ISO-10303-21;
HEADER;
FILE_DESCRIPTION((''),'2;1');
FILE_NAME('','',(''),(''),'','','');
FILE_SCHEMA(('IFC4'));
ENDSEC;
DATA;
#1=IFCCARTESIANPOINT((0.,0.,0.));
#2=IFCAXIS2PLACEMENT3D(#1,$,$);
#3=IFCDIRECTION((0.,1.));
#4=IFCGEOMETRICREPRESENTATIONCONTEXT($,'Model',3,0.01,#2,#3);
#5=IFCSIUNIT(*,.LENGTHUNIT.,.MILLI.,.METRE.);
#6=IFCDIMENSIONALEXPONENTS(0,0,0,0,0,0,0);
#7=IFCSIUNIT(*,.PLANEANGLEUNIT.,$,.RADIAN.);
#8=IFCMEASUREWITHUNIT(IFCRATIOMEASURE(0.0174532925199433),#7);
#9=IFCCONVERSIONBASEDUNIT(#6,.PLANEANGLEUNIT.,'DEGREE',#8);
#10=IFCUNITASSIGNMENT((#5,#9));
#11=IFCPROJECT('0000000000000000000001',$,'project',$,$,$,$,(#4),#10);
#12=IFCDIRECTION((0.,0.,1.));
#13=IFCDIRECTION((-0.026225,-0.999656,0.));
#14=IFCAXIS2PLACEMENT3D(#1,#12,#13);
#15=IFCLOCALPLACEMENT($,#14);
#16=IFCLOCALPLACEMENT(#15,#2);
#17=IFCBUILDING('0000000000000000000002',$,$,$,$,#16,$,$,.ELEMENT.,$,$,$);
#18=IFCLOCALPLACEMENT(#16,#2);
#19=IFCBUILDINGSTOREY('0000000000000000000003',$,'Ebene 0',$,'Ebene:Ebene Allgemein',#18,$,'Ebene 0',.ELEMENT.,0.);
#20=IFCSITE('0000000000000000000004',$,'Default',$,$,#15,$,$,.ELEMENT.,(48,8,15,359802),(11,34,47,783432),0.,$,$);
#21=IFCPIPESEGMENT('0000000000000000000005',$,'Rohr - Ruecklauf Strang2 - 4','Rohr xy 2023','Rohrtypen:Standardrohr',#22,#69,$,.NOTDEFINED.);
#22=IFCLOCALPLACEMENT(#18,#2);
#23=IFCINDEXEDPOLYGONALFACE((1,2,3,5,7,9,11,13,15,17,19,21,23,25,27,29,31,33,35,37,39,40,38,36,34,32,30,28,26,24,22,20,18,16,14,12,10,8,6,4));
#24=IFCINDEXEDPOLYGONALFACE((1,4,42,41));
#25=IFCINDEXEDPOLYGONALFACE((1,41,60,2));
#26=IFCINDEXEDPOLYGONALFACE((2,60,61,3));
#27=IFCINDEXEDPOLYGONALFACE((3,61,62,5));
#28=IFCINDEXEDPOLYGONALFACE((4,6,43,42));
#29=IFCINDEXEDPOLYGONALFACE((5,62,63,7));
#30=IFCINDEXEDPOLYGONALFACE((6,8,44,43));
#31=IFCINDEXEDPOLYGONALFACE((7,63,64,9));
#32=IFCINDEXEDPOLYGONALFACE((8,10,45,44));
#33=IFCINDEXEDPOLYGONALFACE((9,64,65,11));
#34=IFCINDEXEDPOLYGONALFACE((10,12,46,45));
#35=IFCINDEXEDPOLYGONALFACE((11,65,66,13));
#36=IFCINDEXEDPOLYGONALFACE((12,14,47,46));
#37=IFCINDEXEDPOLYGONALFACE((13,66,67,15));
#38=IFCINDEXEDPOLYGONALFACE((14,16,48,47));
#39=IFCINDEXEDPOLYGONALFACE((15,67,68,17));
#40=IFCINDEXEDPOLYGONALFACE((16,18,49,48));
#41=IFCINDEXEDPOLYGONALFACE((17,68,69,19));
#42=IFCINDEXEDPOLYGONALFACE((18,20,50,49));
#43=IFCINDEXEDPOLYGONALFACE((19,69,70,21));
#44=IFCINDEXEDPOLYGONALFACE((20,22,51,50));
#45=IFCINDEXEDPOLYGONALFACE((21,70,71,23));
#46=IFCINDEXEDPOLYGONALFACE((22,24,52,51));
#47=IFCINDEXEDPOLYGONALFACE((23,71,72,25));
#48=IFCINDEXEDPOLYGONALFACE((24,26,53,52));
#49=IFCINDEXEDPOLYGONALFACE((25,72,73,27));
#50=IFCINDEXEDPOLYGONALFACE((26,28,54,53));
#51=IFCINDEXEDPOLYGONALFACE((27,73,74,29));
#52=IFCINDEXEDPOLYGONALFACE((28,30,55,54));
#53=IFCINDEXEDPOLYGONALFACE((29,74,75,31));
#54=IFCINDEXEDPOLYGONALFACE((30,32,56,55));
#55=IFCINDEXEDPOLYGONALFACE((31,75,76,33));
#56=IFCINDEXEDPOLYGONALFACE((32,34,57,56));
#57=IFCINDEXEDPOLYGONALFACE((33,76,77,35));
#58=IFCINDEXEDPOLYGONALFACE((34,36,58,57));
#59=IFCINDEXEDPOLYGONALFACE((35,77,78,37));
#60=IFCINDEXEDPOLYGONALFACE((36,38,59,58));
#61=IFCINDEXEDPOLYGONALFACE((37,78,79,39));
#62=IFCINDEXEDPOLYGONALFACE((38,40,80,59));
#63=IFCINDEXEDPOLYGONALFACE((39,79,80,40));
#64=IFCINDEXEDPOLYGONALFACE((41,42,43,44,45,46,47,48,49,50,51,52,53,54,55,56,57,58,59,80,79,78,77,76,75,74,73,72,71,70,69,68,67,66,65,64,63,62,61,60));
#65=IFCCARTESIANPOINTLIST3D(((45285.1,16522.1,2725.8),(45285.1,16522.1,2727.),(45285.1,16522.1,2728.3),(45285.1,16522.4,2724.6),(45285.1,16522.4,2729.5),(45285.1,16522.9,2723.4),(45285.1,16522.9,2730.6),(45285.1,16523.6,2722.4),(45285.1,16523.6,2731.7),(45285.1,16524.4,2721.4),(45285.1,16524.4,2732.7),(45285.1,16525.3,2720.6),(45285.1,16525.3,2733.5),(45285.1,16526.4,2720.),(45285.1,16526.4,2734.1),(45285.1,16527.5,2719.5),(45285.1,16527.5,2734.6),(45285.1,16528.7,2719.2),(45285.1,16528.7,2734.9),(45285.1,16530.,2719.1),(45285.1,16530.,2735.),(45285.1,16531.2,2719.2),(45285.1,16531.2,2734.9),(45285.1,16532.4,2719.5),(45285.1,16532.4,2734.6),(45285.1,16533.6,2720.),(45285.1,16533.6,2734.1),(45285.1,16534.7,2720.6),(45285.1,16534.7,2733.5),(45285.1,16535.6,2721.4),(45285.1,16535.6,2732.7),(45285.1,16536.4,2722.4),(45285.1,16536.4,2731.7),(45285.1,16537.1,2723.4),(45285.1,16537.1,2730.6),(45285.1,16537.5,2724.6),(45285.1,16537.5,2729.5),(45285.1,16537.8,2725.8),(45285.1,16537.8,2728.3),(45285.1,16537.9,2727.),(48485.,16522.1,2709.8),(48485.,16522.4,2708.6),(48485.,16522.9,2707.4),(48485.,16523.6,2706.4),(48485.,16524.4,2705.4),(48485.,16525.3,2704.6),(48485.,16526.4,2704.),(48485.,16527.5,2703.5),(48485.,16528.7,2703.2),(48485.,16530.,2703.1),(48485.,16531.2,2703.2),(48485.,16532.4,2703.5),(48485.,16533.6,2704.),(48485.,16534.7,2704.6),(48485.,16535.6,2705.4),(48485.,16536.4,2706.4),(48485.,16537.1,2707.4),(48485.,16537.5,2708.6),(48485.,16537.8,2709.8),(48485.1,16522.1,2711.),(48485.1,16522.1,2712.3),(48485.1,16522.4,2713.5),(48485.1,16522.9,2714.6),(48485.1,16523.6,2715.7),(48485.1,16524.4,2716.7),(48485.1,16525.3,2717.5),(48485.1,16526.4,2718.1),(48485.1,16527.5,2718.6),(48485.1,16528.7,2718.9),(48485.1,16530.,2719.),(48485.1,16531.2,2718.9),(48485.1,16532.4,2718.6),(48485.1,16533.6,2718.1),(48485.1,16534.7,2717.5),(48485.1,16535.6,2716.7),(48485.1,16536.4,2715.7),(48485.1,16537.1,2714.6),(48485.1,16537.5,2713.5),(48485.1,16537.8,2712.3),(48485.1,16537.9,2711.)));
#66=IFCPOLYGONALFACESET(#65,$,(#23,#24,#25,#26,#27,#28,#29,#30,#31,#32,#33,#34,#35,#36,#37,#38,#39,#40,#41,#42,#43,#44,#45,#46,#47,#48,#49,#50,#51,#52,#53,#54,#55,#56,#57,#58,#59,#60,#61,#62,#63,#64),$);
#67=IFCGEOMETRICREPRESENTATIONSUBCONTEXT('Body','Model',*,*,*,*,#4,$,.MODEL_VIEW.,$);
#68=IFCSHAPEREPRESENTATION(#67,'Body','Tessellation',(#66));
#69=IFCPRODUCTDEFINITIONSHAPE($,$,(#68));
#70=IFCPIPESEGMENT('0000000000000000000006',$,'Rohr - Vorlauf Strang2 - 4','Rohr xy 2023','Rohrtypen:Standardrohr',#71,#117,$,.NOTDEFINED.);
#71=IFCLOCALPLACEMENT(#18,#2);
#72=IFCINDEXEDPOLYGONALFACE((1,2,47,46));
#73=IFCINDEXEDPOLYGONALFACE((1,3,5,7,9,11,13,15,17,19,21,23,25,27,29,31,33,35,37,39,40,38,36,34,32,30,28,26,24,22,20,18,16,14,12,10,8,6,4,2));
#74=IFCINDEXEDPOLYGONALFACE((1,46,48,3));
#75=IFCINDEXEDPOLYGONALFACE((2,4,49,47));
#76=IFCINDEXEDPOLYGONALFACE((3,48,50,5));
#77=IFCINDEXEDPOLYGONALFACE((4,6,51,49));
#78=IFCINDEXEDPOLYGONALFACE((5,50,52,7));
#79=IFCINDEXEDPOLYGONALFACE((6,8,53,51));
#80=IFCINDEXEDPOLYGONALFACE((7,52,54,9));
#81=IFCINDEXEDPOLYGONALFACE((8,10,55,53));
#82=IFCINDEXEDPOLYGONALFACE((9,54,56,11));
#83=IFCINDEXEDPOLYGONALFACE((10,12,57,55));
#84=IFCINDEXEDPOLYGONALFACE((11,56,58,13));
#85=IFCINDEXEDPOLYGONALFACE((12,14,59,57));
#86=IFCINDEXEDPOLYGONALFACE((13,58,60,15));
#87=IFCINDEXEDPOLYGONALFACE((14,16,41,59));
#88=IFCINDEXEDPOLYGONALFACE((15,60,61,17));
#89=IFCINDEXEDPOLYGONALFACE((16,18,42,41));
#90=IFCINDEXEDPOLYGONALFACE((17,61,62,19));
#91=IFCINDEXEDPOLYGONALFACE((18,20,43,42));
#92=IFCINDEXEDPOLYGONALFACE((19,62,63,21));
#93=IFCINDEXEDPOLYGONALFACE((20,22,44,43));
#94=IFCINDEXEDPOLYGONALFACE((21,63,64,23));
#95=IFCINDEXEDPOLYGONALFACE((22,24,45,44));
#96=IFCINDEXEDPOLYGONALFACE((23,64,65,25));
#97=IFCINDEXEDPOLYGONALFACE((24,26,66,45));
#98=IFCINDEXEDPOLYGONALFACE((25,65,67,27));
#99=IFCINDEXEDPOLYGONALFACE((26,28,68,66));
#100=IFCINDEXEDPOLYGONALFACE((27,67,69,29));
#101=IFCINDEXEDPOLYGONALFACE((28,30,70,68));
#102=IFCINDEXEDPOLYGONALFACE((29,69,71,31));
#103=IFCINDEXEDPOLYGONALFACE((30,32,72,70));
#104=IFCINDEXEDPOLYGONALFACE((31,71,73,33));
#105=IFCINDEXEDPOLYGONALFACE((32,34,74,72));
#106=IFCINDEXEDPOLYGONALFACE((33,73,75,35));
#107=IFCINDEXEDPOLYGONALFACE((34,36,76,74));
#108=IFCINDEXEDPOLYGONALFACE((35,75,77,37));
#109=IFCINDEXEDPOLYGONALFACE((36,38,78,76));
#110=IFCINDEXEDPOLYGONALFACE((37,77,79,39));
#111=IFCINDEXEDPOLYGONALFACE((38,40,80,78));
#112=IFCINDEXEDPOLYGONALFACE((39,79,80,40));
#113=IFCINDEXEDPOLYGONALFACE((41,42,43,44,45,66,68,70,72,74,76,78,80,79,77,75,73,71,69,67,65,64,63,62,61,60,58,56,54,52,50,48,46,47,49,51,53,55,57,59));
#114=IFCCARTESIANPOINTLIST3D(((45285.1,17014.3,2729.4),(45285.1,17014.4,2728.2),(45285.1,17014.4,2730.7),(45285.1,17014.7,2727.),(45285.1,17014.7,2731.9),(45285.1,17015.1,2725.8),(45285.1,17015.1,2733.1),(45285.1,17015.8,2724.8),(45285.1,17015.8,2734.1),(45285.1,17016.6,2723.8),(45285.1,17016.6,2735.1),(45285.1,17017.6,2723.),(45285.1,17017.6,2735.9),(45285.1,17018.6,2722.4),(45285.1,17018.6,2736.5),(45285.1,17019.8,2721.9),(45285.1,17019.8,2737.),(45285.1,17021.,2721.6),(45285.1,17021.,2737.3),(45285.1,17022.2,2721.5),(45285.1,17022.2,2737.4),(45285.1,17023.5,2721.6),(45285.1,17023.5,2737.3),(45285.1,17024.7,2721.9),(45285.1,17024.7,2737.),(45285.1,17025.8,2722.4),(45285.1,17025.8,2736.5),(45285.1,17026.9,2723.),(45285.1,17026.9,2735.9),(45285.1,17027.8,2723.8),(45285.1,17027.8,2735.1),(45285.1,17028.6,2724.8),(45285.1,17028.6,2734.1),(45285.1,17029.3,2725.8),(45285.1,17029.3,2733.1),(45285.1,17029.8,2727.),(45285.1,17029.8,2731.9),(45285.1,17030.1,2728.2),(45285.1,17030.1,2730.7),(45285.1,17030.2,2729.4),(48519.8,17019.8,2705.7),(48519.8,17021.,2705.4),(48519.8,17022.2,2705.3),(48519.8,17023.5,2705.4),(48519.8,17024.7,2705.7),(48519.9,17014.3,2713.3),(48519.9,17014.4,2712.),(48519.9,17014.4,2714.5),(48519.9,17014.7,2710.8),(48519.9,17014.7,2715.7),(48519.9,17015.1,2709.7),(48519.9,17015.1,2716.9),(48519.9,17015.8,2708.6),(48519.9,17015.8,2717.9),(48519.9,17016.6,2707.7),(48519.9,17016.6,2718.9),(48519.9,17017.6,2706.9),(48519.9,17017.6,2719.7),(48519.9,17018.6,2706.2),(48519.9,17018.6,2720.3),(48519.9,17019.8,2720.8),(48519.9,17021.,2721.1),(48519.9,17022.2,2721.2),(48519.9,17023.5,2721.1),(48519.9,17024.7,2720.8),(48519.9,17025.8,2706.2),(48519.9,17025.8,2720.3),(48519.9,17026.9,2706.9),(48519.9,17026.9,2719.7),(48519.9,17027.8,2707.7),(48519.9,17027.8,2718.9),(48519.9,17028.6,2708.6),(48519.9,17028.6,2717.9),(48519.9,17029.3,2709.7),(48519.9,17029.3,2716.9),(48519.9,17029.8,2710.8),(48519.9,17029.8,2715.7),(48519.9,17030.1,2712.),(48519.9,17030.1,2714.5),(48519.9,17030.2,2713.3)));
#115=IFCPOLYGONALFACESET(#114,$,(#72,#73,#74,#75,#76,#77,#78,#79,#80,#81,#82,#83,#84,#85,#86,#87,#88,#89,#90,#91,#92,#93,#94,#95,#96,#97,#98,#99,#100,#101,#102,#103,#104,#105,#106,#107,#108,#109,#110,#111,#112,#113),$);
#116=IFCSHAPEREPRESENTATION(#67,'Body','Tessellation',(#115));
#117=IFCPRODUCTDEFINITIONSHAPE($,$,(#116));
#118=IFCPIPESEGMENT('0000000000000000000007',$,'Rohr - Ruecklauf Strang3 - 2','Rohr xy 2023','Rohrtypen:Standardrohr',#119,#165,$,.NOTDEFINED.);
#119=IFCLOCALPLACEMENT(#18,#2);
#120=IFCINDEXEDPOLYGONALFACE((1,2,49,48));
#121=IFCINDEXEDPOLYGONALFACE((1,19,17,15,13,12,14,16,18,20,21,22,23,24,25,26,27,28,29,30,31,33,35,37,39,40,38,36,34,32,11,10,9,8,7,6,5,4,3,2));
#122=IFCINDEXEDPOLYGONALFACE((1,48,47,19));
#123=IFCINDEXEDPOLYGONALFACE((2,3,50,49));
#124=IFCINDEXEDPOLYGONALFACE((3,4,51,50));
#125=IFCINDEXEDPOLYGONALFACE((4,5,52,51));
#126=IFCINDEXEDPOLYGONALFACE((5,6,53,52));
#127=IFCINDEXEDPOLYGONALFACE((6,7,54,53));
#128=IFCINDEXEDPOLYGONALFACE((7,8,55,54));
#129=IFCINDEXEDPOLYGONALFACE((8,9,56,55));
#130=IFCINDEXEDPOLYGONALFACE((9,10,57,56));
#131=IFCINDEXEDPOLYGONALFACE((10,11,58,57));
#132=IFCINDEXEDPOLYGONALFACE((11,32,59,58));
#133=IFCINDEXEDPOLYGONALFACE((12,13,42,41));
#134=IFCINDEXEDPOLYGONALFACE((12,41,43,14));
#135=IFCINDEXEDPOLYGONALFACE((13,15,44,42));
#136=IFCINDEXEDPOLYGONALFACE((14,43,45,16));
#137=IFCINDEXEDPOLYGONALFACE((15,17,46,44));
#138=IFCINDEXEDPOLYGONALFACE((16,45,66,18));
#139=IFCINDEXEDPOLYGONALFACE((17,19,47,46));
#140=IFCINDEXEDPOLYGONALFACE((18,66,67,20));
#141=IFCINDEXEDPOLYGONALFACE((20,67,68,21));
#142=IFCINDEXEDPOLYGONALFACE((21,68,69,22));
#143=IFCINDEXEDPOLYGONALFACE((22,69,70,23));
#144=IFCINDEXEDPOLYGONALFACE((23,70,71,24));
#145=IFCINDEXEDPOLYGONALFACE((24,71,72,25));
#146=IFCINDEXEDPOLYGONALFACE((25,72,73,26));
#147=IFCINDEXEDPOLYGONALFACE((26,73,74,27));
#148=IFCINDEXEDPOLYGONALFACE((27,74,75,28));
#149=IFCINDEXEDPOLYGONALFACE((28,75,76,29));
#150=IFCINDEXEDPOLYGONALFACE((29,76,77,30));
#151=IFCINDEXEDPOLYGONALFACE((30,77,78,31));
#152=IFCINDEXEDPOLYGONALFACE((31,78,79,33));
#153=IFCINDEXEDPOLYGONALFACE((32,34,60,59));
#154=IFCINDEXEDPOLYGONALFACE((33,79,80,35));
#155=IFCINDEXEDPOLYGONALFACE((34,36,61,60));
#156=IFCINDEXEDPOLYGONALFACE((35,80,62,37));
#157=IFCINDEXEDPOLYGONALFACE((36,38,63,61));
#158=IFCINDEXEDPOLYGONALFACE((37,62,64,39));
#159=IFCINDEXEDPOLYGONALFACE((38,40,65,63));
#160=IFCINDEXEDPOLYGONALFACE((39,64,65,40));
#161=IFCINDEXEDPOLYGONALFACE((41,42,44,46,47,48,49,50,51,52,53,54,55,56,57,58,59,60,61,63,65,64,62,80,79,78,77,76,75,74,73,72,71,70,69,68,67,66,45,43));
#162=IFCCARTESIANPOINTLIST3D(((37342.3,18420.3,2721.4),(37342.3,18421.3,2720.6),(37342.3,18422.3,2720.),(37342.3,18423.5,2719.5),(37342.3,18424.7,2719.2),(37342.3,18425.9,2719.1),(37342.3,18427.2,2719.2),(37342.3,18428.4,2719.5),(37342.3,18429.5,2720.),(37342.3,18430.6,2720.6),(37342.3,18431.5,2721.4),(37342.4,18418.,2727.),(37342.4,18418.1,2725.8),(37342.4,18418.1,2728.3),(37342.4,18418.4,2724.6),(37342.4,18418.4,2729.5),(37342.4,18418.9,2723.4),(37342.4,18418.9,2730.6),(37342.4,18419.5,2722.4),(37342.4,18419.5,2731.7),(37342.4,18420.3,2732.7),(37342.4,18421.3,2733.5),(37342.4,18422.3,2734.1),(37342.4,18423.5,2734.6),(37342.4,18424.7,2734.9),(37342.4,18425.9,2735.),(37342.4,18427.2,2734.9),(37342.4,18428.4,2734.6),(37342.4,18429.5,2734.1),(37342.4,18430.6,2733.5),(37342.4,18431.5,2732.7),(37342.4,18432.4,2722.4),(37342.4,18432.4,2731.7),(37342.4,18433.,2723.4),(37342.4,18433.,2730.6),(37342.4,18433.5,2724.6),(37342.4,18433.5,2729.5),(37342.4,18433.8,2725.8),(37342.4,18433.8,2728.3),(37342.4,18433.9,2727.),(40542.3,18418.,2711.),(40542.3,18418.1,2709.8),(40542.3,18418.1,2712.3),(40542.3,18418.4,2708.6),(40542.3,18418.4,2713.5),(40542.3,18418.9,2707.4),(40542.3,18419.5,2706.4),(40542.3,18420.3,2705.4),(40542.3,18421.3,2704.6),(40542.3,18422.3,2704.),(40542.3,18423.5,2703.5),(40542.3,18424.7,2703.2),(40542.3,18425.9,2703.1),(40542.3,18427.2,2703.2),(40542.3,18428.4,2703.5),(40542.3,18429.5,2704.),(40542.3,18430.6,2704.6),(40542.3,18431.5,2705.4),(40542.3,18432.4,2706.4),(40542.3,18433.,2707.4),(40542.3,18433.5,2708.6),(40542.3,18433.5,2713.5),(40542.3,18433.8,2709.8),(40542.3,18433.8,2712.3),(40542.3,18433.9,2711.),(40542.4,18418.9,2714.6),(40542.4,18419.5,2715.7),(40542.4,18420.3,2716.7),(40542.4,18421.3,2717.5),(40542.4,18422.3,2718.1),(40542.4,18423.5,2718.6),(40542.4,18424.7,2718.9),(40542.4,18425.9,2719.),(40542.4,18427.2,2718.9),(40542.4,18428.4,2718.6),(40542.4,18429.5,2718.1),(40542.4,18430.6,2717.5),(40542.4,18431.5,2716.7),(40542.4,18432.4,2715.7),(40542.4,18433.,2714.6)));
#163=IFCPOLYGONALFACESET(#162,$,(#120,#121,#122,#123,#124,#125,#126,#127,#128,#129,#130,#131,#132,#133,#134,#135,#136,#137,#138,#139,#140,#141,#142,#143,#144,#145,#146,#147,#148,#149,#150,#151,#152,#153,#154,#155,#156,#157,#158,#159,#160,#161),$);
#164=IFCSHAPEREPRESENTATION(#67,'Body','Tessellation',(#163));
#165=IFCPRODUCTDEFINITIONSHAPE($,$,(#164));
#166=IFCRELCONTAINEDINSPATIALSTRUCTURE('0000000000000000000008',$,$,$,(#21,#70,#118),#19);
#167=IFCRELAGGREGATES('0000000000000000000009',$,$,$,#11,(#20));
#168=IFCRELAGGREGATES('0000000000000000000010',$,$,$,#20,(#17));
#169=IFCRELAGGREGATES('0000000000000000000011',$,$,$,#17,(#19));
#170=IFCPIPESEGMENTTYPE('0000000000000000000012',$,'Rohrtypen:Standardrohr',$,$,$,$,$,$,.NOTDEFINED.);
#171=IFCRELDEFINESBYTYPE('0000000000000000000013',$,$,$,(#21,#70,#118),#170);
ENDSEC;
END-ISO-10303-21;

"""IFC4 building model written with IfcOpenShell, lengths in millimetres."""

from ifc_helpers import new_model, entity, si_unit, converted_unit, direction, frame, origin, place, context, subcontext, project, spatial, indexed_curve, outline, extrude, type_object, element, save


model = new_model("IFC4")

# Units and contexts
model_context = context("Model", 3, precision=0.01, world=origin(), true_north=direction((0.0, 1.0)))
body_context = subcontext(model_context, "Body", "Model", "MODEL_VIEW")
ifc_project = project(units=[si_unit("LENGTHUNIT", "METRE", prefix="MILLI"), converted_unit("PLANEANGLEUNIT", "DEGREE", entity("IfcRatioMeasure", 0.0174532925199433), si_unit("PLANEANGLEUNIT", "RADIAN"), dimensions=[0, 0, 0, 0, 0, 0, 0])], contexts=[model_context])

# Site, building, storey
site_placement = place(None, frame((0.0, 0.0, 0.0), z_axis=(0.0, 0.0, 1.0), x_axis=(-0.026225, -0.999656, 0.0)))
site = spatial("IfcSite", under=ifc_project, at=site_placement, Name="Default", CompositionType="ELEMENT", RefLatitude=(48, 8, 15, 359802), RefLongitude=(11, 34, 47, 783432), RefElevation=0.0)
building_placement = place(site_placement, origin())
building = spatial("IfcBuilding", under=site, at=building_placement, CompositionType="ELEMENT")
storey_placement = place(building_placement, origin())
storey = spatial("IfcBuildingStorey", under=building, at=storey_placement, Name="Ebene 0", ObjectType="Ebene:Ebene Allgemein", LongName="Ebene 0", CompositionType="ELEMENT", Elevation=0.0)

# Pipe segments
pipe_segment_type = type_object("IfcPipeSegmentType", Name="Rohrtypen:Standardrohr", PredefinedType="NOTDEFINED")
pipe_segment_1_placement = place(storey_placement, origin())
element("IfcPipeSegment", 1, at=pipe_segment_1_placement, inside=storey, type_object=pipe_segment_type, Name="Rohr - Ruecklauf Strang2 - 4", Description="Rohr xy 2023", ObjectType="Rohrtypen:Standardrohr", PredefinedType="NOTDEFINED", context=body_context, shape_type="SweptSolid", body=[
    extrude(outline(indexed_curve([(7.9, 0.0), (7.8, 1.2), (7.6, 2.5), (7.1, 3.6), (6.4, 4.7), (5.6, 5.6), (4.7, 6.4), (3.6, 7.1), (2.5, 7.6), (1.2, 7.8), (0.0, 7.9), (-1.2, 7.8), (-2.5, 7.6), (-3.6, 7.1), (-4.7, 6.4), (-5.6, 5.6), (-6.4, 4.7), (-7.1, 3.6), (-7.6, 2.5), (-7.8, 1.2), (-7.9, 0.0), (-7.8, -1.2), (-7.6, -2.5), (-7.1, -3.6), (-6.4, -4.7), (-5.6, -5.6), (-4.7, -6.4), (-3.6, -7.1), (-2.5, -7.6), (-1.2, -7.8), (0.0, -7.9), (1.2, -7.8), (2.5, -7.6), (3.6, -7.1), (4.7, -6.4), (5.6, -5.6), (6.4, -4.7), (7.1, -3.6), (7.6, -2.5), (7.8, -1.2), (7.9, 0.0)], self_intersect=False)), frame((48485.1, 16530.0, 2711.0), z_axis=(-0.999988, 0.0, 0.005), x_axis=(0.0, 1.0, 0.0)), (0.0, 0.0, 1.0), 3200.0),
])
pipe_segment_2_placement = place(storey_placement, origin())
element("IfcPipeSegment", 2, at=pipe_segment_2_placement, inside=storey, type_object=pipe_segment_type, Name="Rohr - Vorlauf Strang2 - 4", Description="Rohr xy 2023", ObjectType="Rohrtypen:Standardrohr", PredefinedType="NOTDEFINED", context=body_context, shape_type="SweptSolid", body=[
    extrude(outline(indexed_curve([(7.9, 0.0), (7.8, 1.2), (7.6, 2.5), (7.1, 3.6), (6.4, 4.7), (5.6, 5.6), (4.7, 6.4), (3.6, 7.1), (2.5, 7.6), (1.2, 7.8), (0.0, 7.9), (-1.2, 7.8), (-2.5, 7.6), (-3.6, 7.1), (-4.7, 6.4), (-5.6, 5.6), (-6.4, 4.7), (-7.1, 3.6), (-7.6, 2.5), (-7.8, 1.2), (-7.9, 0.0), (-7.8, -1.2), (-7.6, -2.5), (-7.1, -3.6), (-6.4, -4.7), (-5.6, -5.6), (-4.7, -6.4), (-3.6, -7.1), (-2.5, -7.6), (-1.2, -7.8), (0.0, -7.9), (1.2, -7.8), (2.5, -7.6), (3.6, -7.1), (4.7, -6.4), (5.6, -5.6), (6.4, -4.7), (7.1, -3.6), (7.6, -2.5), (7.8, -1.2), (7.9, 0.0)], self_intersect=False)), frame((48519.9, 17022.2, 2713.3), z_axis=(-0.999988, 0.0, 0.005), x_axis=(0.0, 1.0, 0.0)), (0.0, 0.0, 1.0), 3234.8),
])
pipe_segment_3_placement = place(storey_placement, origin())
element("IfcPipeSegment", 3, at=pipe_segment_3_placement, inside=storey, type_object=pipe_segment_type, Name="Rohr - Ruecklauf Strang3 - 2", Description="Rohr xy 2023", ObjectType="Rohrtypen:Standardrohr", PredefinedType="NOTDEFINED", context=body_context, shape_type="SweptSolid", body=[
    extrude(outline(indexed_curve([(7.9, 0.0), (7.8, 1.2), (7.6, 2.5), (7.1, 3.6), (6.4, 4.7), (5.6, 5.6), (4.7, 6.4), (3.6, 7.1), (2.5, 7.6), (1.2, 7.8), (0.0, 7.9), (-1.2, 7.8), (-2.5, 7.6), (-3.6, 7.1), (-4.7, 6.4), (-5.6, 5.6), (-6.4, 4.7), (-7.1, 3.6), (-7.6, 2.5), (-7.8, 1.2), (-7.9, 0.0), (-7.8, -1.2), (-7.6, -2.5), (-7.1, -3.6), (-6.4, -4.7), (-5.6, -5.6), (-4.7, -6.4), (-3.6, -7.1), (-2.5, -7.6), (-1.2, -7.8), (0.0, -7.9), (1.2, -7.8), (2.5, -7.6), (3.6, -7.1), (4.7, -6.4), (5.6, -5.6), (6.4, -4.7), (7.1, -3.6), (7.6, -2.5), (7.8, -1.2), (7.9, 0.0)], self_intersect=False)), frame((40542.3, 18425.9, 2711.0), z_axis=(-0.999988, 0.0, 0.005), x_axis=(0.0, 1.0, 0.0)), (0.0, 0.0, 1.0), 3200.0),
])

save(model, "model.ifc")
